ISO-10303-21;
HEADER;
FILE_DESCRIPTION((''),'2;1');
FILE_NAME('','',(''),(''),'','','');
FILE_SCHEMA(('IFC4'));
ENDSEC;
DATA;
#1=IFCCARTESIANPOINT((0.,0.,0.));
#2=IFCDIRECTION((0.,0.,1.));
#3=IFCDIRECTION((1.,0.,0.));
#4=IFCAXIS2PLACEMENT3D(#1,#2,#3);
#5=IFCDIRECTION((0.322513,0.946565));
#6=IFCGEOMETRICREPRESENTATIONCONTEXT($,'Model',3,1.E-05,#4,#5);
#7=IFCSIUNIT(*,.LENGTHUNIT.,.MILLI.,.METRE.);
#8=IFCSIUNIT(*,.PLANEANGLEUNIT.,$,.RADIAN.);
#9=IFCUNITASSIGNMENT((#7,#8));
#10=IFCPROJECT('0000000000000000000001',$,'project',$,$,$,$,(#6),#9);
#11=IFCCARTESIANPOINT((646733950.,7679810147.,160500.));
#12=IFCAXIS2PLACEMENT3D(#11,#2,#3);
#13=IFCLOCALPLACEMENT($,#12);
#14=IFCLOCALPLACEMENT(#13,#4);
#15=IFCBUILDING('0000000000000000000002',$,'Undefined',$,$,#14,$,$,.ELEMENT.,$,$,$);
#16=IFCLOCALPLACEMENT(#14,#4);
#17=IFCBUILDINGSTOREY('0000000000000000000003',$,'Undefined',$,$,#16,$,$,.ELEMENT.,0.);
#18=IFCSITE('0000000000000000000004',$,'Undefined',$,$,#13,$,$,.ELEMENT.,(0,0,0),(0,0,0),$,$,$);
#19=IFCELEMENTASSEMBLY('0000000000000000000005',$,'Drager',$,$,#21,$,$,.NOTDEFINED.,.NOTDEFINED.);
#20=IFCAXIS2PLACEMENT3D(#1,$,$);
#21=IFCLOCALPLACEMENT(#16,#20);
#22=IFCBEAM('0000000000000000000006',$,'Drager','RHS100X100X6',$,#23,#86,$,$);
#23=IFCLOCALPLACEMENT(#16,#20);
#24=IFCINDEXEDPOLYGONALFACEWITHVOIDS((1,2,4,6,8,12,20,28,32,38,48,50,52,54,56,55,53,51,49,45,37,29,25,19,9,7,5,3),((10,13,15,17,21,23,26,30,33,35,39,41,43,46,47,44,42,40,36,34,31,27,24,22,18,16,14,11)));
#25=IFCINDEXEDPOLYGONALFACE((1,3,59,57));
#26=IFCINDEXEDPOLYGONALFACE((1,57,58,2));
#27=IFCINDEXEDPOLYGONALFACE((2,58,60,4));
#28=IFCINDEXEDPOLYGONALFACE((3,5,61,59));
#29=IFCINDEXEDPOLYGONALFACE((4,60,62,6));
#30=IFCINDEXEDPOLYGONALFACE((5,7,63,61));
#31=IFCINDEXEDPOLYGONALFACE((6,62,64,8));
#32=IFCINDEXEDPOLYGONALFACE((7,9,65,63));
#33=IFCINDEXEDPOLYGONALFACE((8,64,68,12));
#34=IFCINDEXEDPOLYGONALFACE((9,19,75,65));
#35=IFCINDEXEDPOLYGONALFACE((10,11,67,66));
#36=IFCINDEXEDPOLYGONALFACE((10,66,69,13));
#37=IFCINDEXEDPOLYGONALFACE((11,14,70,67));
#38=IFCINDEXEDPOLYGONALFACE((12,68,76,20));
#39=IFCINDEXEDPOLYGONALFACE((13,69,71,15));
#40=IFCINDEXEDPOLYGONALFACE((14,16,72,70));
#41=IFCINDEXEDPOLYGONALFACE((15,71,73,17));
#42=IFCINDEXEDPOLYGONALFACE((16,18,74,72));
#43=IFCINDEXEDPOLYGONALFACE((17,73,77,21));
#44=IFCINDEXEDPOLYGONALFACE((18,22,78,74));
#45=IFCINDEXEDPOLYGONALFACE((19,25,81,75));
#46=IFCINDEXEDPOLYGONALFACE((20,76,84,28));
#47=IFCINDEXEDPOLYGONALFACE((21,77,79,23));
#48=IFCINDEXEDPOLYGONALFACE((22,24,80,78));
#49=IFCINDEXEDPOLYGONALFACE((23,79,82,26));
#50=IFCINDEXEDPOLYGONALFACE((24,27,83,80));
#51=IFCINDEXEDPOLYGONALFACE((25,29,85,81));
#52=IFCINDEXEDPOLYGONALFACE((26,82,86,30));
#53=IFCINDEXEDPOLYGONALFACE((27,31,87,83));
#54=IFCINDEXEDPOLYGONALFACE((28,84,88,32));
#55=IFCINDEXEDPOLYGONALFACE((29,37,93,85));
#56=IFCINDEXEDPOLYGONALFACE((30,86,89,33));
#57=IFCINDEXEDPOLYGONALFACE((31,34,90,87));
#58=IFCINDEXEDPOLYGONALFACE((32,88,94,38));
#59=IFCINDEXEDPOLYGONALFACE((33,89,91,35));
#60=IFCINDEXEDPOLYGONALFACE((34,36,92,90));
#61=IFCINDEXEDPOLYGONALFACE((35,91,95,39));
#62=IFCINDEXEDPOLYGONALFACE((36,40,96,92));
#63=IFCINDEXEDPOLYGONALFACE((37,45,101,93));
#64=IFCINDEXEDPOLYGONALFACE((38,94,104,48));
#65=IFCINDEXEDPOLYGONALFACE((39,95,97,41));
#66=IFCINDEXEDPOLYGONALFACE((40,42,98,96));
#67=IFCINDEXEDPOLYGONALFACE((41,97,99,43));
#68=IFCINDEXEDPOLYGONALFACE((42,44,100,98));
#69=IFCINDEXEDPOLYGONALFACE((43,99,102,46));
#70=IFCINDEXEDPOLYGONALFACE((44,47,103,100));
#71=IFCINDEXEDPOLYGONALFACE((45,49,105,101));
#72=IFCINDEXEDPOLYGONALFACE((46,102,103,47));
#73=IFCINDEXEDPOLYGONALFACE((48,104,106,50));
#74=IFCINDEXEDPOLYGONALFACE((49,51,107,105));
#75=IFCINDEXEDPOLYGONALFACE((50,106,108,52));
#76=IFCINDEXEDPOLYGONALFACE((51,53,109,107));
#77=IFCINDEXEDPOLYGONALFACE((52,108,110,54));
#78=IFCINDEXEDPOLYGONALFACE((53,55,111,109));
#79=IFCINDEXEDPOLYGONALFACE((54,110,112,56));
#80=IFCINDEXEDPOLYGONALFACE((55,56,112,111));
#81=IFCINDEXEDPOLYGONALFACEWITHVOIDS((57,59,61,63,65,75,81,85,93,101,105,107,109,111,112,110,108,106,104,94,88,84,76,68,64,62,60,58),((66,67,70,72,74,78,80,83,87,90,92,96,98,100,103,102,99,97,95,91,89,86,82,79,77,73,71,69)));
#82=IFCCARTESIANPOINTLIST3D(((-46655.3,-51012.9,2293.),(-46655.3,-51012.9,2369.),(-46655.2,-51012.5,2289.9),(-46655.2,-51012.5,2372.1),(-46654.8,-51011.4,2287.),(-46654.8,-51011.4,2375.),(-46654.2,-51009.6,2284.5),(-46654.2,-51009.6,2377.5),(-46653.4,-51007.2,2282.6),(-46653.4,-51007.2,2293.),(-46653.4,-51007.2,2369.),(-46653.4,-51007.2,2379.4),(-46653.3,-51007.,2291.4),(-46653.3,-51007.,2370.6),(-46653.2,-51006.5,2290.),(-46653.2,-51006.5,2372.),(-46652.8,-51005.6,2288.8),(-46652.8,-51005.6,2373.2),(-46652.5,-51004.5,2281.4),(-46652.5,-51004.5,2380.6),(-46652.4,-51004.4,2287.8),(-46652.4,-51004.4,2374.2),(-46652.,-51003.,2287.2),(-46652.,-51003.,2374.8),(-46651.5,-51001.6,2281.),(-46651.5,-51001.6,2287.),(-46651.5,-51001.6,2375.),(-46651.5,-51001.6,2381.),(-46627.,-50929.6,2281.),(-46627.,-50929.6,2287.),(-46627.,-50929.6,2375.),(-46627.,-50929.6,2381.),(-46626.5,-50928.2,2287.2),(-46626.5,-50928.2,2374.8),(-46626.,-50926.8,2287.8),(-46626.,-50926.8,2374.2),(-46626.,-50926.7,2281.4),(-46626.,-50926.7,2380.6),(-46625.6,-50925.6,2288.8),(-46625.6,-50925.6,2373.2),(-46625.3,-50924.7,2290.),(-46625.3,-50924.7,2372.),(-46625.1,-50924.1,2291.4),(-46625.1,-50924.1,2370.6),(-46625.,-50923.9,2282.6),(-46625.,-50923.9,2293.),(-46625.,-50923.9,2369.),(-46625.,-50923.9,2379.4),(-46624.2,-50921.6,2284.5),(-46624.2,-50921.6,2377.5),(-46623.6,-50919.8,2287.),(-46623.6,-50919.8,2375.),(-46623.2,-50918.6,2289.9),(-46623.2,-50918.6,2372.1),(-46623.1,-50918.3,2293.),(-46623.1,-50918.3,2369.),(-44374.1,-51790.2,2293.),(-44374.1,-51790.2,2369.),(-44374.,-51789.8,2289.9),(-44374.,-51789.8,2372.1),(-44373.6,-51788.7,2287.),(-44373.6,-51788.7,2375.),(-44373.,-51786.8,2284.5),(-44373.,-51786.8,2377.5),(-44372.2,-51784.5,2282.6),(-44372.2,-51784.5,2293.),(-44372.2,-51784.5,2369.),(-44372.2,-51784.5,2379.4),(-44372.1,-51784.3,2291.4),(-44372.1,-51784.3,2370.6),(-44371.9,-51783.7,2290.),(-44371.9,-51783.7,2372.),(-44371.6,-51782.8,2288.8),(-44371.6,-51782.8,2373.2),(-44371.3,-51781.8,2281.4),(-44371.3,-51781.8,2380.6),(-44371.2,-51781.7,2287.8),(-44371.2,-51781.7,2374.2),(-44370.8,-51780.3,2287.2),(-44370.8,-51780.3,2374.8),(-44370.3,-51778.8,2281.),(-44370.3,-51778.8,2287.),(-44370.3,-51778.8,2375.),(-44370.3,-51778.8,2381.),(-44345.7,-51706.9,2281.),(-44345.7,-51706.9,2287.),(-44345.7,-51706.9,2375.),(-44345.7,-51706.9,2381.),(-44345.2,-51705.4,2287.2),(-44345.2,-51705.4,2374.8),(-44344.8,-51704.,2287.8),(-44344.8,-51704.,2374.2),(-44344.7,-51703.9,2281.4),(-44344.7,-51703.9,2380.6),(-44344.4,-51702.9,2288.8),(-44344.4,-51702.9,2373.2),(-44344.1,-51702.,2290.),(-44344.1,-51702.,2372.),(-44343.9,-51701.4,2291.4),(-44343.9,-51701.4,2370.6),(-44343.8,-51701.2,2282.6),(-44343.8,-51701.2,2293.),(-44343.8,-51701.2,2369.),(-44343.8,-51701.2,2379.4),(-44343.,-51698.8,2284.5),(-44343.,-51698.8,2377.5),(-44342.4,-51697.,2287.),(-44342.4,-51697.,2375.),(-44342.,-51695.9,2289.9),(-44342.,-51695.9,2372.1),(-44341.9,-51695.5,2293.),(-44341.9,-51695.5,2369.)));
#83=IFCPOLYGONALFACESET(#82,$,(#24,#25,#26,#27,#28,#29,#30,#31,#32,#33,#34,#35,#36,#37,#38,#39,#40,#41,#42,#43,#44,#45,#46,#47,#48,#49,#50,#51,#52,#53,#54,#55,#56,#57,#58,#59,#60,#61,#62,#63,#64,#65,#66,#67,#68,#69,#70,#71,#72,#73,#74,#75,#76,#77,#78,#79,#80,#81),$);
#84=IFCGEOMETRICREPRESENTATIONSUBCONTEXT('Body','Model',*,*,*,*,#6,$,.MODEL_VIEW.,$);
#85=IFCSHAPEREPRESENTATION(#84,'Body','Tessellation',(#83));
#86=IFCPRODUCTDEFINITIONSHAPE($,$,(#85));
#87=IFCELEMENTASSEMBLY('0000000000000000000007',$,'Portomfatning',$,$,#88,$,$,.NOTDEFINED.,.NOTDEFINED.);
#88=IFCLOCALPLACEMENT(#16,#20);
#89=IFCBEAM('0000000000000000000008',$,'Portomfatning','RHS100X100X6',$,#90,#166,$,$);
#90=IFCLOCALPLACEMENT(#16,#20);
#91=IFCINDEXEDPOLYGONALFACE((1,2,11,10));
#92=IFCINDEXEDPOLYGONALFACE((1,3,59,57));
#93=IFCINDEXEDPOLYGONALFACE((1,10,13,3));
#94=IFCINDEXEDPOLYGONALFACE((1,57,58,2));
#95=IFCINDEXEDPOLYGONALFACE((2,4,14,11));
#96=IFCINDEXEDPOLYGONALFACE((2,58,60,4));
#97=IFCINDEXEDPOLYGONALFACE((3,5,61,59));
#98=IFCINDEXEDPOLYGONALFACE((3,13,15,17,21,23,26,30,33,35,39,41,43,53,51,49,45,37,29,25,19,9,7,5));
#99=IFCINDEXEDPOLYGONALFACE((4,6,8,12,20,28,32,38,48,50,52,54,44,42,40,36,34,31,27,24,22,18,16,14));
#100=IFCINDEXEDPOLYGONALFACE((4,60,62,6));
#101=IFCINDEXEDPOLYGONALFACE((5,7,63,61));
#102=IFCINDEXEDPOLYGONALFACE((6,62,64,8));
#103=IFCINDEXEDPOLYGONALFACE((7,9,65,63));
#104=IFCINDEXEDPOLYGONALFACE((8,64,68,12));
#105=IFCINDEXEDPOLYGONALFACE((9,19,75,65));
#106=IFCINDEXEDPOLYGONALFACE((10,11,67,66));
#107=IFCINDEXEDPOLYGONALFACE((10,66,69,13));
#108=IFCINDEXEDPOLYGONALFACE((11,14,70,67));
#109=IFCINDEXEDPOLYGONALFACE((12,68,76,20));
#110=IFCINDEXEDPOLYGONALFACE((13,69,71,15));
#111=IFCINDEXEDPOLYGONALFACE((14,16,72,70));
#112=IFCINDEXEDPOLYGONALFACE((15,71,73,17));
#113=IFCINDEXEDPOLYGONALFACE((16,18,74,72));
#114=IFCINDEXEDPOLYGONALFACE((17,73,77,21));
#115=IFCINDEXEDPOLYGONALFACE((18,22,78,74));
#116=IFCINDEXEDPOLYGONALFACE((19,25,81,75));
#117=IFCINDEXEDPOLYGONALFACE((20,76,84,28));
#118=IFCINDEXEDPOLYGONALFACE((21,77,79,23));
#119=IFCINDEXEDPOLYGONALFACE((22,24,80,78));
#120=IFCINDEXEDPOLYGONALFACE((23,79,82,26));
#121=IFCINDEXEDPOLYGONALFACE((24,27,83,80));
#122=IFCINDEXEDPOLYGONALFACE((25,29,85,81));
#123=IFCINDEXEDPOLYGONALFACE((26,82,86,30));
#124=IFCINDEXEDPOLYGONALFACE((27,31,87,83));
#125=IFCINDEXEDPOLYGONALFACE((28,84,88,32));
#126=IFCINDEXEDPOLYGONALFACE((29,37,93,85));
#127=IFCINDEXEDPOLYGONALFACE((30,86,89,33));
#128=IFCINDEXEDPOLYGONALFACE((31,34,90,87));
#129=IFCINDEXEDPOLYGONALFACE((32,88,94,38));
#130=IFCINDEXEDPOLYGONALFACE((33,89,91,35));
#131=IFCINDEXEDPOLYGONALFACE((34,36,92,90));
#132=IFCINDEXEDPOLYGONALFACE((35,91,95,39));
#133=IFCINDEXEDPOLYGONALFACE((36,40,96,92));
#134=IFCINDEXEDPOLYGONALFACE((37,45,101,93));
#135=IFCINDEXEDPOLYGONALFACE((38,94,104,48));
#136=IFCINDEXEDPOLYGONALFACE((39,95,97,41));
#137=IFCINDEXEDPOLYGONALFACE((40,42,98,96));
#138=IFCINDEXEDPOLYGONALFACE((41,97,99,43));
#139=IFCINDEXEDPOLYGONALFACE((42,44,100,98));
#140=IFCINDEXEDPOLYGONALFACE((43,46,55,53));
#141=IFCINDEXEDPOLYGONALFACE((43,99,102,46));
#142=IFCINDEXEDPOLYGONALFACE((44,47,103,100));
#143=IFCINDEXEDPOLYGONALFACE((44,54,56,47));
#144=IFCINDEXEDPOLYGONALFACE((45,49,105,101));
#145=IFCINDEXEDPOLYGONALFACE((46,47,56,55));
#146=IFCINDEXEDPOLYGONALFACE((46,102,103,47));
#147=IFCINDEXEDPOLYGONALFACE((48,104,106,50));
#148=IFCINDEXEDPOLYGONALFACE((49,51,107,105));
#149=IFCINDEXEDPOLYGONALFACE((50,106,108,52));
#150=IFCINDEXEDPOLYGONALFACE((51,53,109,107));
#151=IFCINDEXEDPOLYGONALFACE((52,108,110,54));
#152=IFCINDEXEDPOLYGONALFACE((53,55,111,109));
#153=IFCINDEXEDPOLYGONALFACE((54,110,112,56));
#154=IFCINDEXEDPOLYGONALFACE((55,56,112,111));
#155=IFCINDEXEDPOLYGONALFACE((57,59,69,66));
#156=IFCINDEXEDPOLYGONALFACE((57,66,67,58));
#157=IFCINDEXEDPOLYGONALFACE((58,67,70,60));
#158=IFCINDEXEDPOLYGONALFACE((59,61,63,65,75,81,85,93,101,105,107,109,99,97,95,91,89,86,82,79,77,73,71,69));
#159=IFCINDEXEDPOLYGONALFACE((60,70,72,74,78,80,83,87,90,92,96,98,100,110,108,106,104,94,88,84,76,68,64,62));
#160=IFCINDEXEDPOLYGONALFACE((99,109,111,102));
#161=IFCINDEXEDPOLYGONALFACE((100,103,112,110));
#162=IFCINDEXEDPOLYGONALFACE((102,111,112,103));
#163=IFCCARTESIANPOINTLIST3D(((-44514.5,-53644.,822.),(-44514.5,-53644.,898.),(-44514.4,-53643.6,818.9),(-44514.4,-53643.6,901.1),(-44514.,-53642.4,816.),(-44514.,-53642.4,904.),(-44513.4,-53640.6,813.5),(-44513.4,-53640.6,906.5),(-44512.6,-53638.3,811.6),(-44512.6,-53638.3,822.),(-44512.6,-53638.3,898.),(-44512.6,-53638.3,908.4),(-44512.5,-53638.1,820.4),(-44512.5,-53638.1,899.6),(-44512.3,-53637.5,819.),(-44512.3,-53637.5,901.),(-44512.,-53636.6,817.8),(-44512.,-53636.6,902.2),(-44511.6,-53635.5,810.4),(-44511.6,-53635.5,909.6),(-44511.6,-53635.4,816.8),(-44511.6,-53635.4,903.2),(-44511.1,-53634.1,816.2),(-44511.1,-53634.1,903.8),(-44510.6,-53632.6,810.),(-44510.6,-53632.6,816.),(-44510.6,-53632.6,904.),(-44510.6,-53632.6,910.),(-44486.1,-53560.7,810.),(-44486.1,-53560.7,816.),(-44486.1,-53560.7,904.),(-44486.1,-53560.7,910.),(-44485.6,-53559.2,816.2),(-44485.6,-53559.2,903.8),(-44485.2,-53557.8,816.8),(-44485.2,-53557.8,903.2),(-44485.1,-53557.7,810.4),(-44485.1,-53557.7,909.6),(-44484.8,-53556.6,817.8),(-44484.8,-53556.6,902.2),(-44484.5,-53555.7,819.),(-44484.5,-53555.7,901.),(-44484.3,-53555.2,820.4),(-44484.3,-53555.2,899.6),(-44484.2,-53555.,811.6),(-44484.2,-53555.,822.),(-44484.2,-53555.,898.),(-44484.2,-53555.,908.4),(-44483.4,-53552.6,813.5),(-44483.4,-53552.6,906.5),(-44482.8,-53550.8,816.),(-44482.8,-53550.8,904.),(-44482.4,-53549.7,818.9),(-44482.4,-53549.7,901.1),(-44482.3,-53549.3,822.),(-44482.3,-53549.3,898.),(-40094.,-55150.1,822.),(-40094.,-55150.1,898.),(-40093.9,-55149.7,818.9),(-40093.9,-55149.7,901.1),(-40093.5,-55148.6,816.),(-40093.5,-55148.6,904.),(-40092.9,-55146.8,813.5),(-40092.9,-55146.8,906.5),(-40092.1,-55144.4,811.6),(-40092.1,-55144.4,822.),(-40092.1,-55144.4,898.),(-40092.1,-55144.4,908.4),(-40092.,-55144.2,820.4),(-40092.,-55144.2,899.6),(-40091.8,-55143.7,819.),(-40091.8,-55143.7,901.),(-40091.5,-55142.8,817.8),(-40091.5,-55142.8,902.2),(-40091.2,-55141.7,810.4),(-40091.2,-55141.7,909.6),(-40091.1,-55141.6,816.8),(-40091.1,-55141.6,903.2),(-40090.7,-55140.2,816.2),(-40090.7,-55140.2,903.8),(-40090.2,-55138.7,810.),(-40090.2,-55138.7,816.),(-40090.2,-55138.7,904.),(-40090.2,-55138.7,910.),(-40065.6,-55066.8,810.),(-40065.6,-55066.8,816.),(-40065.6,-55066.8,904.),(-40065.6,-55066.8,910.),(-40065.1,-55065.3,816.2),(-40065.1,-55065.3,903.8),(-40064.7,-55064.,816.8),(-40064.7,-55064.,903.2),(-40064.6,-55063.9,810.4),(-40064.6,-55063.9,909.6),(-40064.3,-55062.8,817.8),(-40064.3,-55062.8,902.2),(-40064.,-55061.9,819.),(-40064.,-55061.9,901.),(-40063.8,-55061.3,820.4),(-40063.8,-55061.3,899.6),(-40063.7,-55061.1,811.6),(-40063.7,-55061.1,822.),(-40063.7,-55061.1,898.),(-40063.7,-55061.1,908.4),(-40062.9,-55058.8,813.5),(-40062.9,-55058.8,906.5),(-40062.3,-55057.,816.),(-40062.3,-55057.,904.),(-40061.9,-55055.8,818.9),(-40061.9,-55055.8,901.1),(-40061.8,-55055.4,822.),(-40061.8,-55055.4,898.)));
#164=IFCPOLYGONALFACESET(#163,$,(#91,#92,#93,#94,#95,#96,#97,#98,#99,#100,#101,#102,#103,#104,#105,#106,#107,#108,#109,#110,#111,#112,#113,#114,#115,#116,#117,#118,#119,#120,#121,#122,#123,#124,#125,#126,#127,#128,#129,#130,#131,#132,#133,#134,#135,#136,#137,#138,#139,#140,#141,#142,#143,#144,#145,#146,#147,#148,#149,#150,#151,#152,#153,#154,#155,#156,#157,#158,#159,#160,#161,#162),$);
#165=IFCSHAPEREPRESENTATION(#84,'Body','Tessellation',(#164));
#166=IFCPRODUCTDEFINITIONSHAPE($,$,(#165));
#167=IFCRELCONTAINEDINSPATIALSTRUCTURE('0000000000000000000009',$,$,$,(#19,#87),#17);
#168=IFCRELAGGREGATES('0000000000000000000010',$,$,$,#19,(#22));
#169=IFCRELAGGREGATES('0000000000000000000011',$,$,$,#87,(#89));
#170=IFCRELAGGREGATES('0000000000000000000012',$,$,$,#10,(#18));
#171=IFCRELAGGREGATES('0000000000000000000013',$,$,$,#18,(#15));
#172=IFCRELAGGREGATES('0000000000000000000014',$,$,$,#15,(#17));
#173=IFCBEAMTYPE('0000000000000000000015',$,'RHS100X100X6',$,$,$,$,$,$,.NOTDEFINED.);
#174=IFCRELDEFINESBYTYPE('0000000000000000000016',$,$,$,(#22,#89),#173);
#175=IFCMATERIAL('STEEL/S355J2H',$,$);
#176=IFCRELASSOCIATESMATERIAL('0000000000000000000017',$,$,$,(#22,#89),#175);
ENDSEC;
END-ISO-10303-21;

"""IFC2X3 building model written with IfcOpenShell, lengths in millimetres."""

from ifc_helpers import new_model, si_unit, direction, frame, origin_with_axes, origin_2d_with_axis, place, context, subcontext, project, spatial, hollow_rectangle, extrude, clip, halfspace, material, type_object, element, aggregate, save


model = new_model("IFC2X3")

# Units and contexts
model_context = context("Model", 3, precision=1e-05, world=origin_with_axes(), true_north=direction((0.322513, 0.946565)))
body_context = subcontext(model_context, "Body", "Model", "MODEL_VIEW")
ifc_project = project(units=[si_unit("LENGTHUNIT", "METRE", prefix="MILLI"), si_unit("PLANEANGLEUNIT", "RADIAN")], contexts=[model_context])

# Site, building, storey
site_placement = place(None, frame((646733950.0, 7679810147.0, 160500.0), z_axis=(0.0, 0.0, 1.0), x_axis=(1.0, 0.0, 0.0)))
site = spatial("IfcSite", under=ifc_project, at=site_placement, Name="Undefined", CompositionType="ELEMENT", RefLatitude=(0, 0, 0), RefLongitude=(0, 0, 0))
building_placement = place(site_placement, origin_with_axes())
building = spatial("IfcBuilding", under=site, at=building_placement, Name="Undefined", CompositionType="ELEMENT")
storey_placement = place(building_placement, origin_with_axes())
storey = spatial("IfcBuildingStorey", under=building, at=storey_placement, Name="Undefined", CompositionType="ELEMENT", Elevation=0.0)

# Shared definitions
ifc_material_1 = material(Name="STEEL/S355J2H")

# Element assemblies, beams
beam_type_1 = type_object("IfcBeamType", Name="RHS100X100X6", PredefinedType="NOTDEFINED")
assembly_1_placement = place(storey_placement, origin_with_axes())
assembly_1 = element("IfcElementAssembly", 1, at=assembly_1_placement, inside=storey, Name="Drager", AssemblyPlace="NOTDEFINED", PredefinedType="NOTDEFINED")
beam_1_placement = place(assembly_1_placement, frame((-44358.0, -51742.8, 2331.0), z_axis=(0.0, 0.0, 1.0), x_axis=(-0.946565, 0.322513, 0.0)))
beam_1 = element("IfcBeam", 2, at=beam_1_placement, type_object=beam_type_1, material=ifc_material_1, Name="Drager", Description="RHS100X100X6", context=body_context, shape_type="SweptSolid", body=[
    extrude(hollow_rectangle(XDim=100.0, YDim=100.0, WallThickness=6.0, InnerFilletRadius=6.0, OuterFilletRadius=12.0, at=origin_2d_with_axis()), frame((2410.0, 0.0, 0.0), z_axis=(-1.0, 0.0, 0.0), x_axis=(0.0, -1.0, 0.0)), (0.0, 0.0, 1.0), 2410.0),
])
aggregate(assembly_1, [beam_1])
assembly_2_placement = place(storey_placement, origin_with_axes())
assembly_2 = element("IfcElementAssembly", 3, at=assembly_2_placement, inside=storey, Name="Portomfatning", AssemblyPlace="NOTDEFINED", PredefinedType="NOTDEFINED")
beam_2_placement = place(assembly_2_placement, frame((-44512.6, -53591.8, 860.0), z_axis=(0.322513, 0.946565, 0.0), x_axis=(0.946565, -0.322513, 0.0)))
beam_2 = element("IfcBeam", 4, at=beam_2_placement, type_object=beam_type_1, material=ifc_material_1, Name="Portomfatning", Description="RHS100X100X6", context=body_context, shape_type="Clipping", body=[
    clip(clip(extrude(hollow_rectangle(XDim=100.0, YDim=100.0, WallThickness=6.0, InnerFilletRadius=6.0, OuterFilletRadius=12.0, at=origin_2d_with_axis()), frame((4746.7, 0.0, 0.0), z_axis=(-1.0, 0.0, 0.0), x_axis=(0.0, -1.0, 0.0)), (0.0, 0.0, 1.0), 4793.4), halfspace(frame((4685.0, -50.0, -50.0), z_axis=(-1.0, 0.0, 0.000185), x_axis=(0.0, 1.0, 0.0)), True)), halfspace(frame((15.0, 50.0, -50.0), z_axis=(1.0, 0.0, 0.000185), x_axis=(0.0, -1.0, 0.0)), True)),
])

aggregate(assembly_2, [beam_2])

save(model, "model.ifc")
